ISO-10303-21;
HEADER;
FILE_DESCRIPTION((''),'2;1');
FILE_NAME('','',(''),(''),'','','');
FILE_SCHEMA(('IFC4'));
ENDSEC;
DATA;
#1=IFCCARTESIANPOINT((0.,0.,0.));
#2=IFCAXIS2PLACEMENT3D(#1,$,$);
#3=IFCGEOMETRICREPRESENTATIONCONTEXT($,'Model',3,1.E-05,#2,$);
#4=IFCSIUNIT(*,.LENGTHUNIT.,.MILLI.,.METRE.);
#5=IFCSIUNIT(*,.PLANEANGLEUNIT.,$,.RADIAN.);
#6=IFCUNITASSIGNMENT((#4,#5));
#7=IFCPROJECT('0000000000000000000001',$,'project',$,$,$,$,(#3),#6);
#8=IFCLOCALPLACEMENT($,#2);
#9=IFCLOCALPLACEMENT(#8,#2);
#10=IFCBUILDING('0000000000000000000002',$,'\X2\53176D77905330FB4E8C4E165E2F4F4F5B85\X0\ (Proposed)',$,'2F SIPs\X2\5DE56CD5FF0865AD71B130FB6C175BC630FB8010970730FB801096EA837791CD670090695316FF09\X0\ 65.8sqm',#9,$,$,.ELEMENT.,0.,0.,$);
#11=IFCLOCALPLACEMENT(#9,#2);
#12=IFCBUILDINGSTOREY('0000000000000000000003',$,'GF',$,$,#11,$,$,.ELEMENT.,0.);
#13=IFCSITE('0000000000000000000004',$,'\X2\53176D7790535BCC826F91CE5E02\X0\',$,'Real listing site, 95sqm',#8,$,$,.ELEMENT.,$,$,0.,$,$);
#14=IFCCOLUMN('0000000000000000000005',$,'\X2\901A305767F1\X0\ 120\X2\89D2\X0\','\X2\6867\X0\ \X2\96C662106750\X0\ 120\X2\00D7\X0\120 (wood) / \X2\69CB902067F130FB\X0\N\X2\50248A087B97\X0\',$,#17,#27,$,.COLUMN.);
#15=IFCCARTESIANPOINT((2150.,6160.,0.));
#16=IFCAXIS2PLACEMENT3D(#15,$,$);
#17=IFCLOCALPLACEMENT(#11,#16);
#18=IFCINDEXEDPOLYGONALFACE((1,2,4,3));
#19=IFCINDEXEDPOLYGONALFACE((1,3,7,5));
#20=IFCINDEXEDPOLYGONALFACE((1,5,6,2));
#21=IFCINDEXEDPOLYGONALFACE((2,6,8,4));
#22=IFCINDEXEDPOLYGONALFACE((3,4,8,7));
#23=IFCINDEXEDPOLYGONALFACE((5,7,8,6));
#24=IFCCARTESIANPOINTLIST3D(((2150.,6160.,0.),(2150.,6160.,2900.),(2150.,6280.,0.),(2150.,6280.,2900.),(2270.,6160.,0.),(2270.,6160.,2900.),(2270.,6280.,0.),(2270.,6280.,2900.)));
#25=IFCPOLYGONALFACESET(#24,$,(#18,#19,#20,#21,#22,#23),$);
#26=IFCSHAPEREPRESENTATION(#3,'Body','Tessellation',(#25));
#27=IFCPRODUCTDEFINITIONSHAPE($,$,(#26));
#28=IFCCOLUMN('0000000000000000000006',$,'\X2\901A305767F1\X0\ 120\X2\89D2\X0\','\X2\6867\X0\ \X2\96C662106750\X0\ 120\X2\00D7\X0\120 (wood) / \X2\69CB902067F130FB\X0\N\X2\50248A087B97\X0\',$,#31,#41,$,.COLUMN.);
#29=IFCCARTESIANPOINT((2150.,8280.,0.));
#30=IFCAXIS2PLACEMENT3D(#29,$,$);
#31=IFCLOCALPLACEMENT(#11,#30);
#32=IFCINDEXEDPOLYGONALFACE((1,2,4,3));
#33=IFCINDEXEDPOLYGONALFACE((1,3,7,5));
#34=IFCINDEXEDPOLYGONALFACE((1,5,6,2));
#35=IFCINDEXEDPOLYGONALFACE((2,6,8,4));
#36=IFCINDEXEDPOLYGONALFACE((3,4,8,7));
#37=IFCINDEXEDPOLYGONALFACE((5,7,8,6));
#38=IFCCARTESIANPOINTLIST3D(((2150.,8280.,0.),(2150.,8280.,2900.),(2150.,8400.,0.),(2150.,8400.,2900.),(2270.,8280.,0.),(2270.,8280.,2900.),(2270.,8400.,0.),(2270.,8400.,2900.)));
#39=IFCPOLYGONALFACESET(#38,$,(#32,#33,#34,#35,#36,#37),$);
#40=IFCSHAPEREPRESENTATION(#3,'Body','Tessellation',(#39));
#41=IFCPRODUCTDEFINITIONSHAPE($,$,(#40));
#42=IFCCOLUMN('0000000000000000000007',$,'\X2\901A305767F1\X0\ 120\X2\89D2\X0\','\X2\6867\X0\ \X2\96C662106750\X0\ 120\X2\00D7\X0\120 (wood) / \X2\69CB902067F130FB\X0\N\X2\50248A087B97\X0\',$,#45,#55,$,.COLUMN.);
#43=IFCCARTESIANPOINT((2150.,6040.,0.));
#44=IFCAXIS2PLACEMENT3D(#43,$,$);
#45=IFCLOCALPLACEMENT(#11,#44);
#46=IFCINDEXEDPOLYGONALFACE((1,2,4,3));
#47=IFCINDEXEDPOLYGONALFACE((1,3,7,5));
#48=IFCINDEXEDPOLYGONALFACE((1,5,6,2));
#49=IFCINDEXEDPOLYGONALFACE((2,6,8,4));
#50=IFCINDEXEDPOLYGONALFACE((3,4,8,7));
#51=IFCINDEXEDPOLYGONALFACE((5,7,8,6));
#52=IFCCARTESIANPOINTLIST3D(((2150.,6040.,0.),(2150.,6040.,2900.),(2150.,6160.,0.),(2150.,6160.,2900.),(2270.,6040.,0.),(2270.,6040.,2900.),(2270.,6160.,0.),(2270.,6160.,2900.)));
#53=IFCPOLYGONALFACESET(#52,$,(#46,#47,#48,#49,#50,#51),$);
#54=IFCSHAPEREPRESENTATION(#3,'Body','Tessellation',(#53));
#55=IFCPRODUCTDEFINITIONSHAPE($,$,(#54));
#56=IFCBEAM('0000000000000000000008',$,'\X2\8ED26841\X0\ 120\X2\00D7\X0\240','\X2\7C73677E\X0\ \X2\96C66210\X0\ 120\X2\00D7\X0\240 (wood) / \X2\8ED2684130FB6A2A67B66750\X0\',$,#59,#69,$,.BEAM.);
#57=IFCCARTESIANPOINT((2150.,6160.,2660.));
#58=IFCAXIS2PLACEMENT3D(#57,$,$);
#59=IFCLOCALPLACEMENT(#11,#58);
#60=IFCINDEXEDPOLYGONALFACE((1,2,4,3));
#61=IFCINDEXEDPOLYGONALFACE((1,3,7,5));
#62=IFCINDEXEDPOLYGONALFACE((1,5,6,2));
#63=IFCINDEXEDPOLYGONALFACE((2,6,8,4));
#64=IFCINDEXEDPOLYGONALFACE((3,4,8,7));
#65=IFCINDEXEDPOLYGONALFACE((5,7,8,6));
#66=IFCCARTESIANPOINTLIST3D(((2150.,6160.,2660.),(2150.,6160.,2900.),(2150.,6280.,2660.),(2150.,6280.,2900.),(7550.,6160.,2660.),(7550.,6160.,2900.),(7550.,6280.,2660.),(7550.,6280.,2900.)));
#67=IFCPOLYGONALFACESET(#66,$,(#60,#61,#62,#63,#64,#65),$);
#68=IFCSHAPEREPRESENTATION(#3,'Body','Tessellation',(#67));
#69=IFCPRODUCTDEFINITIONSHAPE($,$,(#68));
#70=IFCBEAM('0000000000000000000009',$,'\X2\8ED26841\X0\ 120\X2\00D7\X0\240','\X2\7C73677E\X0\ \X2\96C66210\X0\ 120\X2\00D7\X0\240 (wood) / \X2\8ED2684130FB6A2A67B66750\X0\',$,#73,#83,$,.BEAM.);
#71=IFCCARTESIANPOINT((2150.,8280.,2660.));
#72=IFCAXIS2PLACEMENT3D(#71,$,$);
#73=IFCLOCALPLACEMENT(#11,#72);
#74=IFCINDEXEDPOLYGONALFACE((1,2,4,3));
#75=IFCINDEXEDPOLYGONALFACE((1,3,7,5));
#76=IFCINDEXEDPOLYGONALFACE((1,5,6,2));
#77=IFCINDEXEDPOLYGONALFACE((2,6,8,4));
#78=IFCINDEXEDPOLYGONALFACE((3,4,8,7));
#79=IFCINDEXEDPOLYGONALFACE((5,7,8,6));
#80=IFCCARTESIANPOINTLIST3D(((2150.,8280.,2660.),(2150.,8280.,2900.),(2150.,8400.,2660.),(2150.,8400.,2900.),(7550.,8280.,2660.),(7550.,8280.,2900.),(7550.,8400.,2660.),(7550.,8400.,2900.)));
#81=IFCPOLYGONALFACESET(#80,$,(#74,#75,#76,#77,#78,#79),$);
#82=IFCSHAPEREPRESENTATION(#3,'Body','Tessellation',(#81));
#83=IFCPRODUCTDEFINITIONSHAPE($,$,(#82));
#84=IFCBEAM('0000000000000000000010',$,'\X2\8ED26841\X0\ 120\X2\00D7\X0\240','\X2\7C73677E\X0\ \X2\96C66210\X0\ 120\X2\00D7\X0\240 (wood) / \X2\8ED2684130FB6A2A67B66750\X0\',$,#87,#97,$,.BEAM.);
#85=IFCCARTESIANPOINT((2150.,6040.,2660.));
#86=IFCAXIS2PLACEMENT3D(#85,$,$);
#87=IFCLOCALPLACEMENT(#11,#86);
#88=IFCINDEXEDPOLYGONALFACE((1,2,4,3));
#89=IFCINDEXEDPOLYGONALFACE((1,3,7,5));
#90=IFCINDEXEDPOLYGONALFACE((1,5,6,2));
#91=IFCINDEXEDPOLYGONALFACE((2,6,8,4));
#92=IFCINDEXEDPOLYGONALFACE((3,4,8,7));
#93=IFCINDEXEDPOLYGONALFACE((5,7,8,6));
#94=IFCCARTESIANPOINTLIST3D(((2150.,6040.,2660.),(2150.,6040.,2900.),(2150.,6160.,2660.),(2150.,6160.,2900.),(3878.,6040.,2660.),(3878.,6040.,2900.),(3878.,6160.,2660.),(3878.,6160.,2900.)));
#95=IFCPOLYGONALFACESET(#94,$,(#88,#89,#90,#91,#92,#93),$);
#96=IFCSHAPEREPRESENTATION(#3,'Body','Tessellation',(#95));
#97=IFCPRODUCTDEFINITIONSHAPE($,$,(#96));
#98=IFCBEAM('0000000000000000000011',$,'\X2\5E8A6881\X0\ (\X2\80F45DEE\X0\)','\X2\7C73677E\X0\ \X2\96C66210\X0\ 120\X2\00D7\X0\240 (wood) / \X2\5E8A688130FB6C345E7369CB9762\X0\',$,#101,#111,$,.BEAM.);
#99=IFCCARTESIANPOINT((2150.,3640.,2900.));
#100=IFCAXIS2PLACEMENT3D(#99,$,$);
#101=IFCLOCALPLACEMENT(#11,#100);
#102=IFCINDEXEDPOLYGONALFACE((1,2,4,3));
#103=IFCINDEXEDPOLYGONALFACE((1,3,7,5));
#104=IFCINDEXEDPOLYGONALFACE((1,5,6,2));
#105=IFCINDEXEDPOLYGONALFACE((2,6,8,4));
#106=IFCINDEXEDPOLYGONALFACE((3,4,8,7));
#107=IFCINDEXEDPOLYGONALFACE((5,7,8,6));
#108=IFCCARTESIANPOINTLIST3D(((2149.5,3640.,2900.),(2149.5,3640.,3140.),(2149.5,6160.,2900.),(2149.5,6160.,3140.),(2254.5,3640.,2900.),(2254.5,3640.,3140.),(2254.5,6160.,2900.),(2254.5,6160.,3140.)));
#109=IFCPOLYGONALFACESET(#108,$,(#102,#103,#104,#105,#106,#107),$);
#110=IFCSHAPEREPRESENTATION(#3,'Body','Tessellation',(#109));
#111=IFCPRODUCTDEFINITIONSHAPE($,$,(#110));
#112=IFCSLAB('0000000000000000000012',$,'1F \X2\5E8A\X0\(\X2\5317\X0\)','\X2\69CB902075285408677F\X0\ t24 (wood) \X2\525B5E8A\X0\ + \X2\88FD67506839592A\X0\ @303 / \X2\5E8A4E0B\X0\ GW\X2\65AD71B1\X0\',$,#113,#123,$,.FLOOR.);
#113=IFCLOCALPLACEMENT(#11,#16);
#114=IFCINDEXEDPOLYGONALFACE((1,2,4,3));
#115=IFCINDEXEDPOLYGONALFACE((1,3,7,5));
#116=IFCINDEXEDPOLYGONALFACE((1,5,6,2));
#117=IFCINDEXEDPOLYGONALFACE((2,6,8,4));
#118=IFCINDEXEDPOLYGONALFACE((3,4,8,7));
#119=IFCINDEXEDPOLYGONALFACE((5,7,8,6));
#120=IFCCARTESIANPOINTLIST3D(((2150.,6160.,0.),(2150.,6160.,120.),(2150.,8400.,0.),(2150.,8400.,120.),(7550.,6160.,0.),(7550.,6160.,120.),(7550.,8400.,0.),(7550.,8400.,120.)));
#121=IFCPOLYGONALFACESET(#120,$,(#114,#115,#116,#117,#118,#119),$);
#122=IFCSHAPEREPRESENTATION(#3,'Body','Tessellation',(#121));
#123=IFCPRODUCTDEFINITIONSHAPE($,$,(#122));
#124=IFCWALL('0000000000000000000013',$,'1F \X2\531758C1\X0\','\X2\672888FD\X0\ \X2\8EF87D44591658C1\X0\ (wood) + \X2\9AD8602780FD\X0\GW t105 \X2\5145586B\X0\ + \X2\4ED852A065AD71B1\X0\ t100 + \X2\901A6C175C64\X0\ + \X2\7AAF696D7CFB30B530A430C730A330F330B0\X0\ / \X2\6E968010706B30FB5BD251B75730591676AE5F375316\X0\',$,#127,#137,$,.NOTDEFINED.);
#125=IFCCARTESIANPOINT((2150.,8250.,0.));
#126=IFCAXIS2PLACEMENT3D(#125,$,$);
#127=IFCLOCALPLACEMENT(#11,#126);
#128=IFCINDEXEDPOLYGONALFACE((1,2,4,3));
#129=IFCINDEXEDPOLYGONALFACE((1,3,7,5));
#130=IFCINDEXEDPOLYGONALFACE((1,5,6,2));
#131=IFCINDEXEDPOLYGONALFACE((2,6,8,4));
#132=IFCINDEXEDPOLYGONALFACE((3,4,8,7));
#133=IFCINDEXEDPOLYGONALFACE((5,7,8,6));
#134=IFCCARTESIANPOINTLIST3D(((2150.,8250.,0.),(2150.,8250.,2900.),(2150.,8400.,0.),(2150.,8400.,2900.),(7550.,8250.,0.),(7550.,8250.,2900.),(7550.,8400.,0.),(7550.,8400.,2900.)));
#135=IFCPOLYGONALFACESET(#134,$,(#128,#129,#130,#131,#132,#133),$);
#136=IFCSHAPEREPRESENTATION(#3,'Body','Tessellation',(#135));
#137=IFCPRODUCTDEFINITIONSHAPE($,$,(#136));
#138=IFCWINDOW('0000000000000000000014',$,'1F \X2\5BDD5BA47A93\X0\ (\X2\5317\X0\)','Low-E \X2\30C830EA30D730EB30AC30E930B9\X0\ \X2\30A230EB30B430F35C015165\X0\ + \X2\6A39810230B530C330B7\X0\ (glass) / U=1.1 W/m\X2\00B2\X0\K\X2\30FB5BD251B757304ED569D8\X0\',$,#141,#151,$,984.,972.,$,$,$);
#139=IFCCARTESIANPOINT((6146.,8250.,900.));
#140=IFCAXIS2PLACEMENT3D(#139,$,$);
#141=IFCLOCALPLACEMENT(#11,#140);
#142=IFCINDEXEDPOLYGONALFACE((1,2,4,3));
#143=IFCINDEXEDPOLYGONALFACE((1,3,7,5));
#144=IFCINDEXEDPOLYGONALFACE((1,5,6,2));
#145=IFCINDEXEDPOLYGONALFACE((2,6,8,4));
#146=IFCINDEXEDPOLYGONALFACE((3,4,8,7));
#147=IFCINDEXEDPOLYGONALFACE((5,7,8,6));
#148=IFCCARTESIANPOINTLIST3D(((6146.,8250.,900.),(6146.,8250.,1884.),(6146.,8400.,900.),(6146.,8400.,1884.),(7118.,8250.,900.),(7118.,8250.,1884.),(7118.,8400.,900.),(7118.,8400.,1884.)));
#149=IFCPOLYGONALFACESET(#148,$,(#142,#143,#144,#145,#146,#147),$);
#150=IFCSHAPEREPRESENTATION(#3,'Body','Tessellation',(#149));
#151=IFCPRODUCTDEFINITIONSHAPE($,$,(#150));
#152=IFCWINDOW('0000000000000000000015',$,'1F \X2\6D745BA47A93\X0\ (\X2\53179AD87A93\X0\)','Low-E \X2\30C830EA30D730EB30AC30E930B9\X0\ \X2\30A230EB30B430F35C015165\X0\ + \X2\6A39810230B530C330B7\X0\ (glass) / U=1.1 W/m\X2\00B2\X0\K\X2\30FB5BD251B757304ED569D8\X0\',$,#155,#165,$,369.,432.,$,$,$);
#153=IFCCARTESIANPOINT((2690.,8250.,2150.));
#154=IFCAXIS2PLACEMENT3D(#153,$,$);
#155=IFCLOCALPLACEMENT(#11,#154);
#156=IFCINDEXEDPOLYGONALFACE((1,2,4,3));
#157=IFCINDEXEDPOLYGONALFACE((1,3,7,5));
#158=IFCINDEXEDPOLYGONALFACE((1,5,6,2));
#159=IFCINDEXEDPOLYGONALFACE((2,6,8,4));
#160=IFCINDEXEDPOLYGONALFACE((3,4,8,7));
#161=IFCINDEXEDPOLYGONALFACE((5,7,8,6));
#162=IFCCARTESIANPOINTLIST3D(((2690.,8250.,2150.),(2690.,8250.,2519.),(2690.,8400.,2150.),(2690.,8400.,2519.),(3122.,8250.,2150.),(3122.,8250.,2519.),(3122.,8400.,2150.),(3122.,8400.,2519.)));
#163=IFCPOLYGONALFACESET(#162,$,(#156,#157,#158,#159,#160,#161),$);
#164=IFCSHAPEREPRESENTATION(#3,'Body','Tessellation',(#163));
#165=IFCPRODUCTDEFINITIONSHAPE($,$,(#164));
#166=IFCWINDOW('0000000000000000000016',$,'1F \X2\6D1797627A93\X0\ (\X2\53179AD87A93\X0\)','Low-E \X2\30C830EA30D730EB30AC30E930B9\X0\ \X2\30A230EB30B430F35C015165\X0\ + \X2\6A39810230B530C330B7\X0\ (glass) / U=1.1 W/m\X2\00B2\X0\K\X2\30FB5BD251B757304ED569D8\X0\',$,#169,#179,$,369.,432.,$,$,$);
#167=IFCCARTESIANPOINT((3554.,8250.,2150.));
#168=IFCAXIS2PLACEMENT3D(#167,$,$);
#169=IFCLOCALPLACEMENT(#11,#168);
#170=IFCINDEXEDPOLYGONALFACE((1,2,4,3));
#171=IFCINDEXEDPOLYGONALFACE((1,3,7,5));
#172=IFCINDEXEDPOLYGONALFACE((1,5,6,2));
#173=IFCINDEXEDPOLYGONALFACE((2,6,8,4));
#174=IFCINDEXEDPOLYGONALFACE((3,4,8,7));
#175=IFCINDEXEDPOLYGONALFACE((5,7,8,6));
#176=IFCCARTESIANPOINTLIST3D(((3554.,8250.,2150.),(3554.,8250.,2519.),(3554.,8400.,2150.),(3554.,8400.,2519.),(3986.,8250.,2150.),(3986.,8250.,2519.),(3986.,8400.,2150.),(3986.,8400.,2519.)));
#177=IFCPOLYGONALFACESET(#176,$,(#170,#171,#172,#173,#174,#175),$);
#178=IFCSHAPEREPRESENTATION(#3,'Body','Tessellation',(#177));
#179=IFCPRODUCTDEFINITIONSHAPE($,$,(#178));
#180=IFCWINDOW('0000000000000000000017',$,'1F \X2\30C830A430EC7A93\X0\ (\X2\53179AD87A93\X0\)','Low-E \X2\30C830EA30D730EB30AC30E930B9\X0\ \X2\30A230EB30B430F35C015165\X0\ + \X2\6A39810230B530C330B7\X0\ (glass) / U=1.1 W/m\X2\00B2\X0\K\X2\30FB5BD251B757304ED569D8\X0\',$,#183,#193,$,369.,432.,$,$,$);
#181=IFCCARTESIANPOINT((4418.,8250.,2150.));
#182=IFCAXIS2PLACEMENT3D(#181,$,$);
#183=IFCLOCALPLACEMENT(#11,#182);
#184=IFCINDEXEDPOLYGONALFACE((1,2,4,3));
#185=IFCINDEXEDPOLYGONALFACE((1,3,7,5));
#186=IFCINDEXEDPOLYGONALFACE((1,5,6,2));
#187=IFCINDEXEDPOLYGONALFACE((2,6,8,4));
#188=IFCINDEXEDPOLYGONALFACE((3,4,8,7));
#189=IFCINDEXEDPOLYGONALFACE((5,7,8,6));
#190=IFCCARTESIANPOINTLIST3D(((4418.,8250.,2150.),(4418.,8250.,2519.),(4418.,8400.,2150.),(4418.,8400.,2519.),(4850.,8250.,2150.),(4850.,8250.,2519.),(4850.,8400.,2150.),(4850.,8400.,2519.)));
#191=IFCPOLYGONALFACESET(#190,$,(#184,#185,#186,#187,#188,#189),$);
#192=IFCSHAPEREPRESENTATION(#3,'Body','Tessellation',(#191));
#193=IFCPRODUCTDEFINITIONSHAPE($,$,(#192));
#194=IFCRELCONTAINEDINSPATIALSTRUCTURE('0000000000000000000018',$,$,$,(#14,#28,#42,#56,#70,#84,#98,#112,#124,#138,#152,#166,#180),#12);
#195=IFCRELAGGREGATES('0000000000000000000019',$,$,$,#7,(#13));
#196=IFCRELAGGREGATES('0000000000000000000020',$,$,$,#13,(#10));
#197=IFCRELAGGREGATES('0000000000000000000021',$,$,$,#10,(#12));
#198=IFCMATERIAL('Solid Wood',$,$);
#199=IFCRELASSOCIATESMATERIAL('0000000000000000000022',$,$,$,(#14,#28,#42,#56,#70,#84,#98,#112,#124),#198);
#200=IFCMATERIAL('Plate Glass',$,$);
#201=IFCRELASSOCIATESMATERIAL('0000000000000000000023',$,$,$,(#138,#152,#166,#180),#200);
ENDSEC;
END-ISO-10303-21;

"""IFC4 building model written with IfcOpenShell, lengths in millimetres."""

from ifc_helpers import new_model, si_unit, frame, frame_2d, origin, place, context, project, spatial, rectangle, extrude, material, element, fill, save


model = new_model("IFC4")

# Units and contexts
model_context = context("Model", 3, precision=1e-05, world=origin())
ifc_project = project(units=[si_unit("LENGTHUNIT", "METRE", prefix="MILLI"), si_unit("PLANEANGLEUNIT", "RADIAN")], contexts=[model_context])

# Site, building, storey
site_placement = place(None, origin())
site = spatial("IfcSite", under=ifc_project, at=site_placement, Name="北海道富良野市", ObjectType="Real listing site, 95sqm", CompositionType="ELEMENT", RefElevation=0.0)
building_placement = place(site_placement, origin())
building = spatial("IfcBuilding", under=site, at=building_placement, Name="北海道・二世帯住宅 (Proposed)", ObjectType="2F SIPs工法（断熱・気密・耐震・耐雪荷重最適化） 65.8sqm", CompositionType="ELEMENT", ElevationOfRefHeight=0.0, ElevationOfTerrain=0.0)
storey_placement = place(building_placement, origin())
storey = spatial("IfcBuildingStorey", under=building, at=storey_placement, Name="GF", CompositionType="ELEMENT", Elevation=0.0)

# Columns
ifc_material_1 = material(Name="Solid Wood")
column_1_placement = place(storey_placement, frame((2150.0, 6160.0, 0.0)))
element("IfcColumn", 1, at=column_1_placement, inside=storey, material=ifc_material_1, Name="通し柱 120角", Description="桧 集成材 120×120 (wood) / 構造柱・N値計算", PredefinedType="COLUMN", context=model_context, shape_type="SweptSolid", body=[
    extrude(rectangle(XDim=120.0, YDim=120.0, at=frame_2d((60.0, 60.0))), frame((2150.0, 6160.0, 0.0)), (0.0, 0.0, 1.0), 2900.0),
])
column_2_placement = place(storey_placement, frame((2150.0, 8280.0, 0.0)))
element("IfcColumn", 2, at=column_2_placement, inside=storey, material=ifc_material_1, Name="通し柱 120角", Description="桧 集成材 120×120 (wood) / 構造柱・N値計算", PredefinedType="COLUMN", context=model_context, shape_type="SweptSolid", body=[
    extrude(rectangle(XDim=120.0, YDim=120.0, at=frame_2d((60.0, 60.0))), frame((2150.0, 8280.0, 0.0)), (0.0, 0.0, 1.0), 2900.0),
])
column_3_placement = place(storey_placement, frame((2150.0, 6040.0, 0.0)))
element("IfcColumn", 3, at=column_3_placement, inside=storey, material=ifc_material_1, Name="通し柱 120角", Description="桧 集成材 120×120 (wood) / 構造柱・N値計算", PredefinedType="COLUMN", context=model_context, shape_type="SweptSolid", body=[
    extrude(rectangle(XDim=120.0, YDim=120.0, at=frame_2d((60.0, 60.0))), frame((2150.0, 6040.0, 0.0)), (0.0, 0.0, 1.0), 2900.0),
])

# Beams
beam_1_placement = place(storey_placement, frame((2150.0, 6160.0, 2660.0)))
element("IfcBeam", 4, at=beam_1_placement, inside=storey, material=ifc_material_1, Name="軒桁 120×240", Description="米松 集成 120×240 (wood) / 軒桁・横架材", PredefinedType="BEAM", context=model_context, shape_type="SweptSolid", body=[
    extrude(rectangle(XDim=5400.0, YDim=120.0, at=frame_2d((2700.0, 60.0))), frame((2150.0, 6160.0, 2660.0)), (0.0, 0.0, 1.0), 240.0),
])
beam_2_placement = place(storey_placement, frame((2150.0, 8280.0, 2660.0)))
element("IfcBeam", 5, at=beam_2_placement, inside=storey, material=ifc_material_1, Name="軒桁 120×240", Description="米松 集成 120×240 (wood) / 軒桁・横架材", PredefinedType="BEAM", context=model_context, shape_type="SweptSolid", body=[
    extrude(rectangle(XDim=5400.0, YDim=120.0, at=frame_2d((2700.0, 60.0))), frame((2150.0, 8280.0, 2660.0)), (0.0, 0.0, 1.0), 240.0),
])
beam_3_placement = place(storey_placement, frame((2150.0, 6040.0, 2660.0)))
element("IfcBeam", 6, at=beam_3_placement, inside=storey, material=ifc_material_1, Name="軒桁 120×240", Description="米松 集成 120×240 (wood) / 軒桁・横架材", PredefinedType="BEAM", context=model_context, shape_type="SweptSolid", body=[
    extrude(rectangle(XDim=1728.0, YDim=120.0, at=frame_2d((864.0, 60.0))), frame((2150.0, 6040.0, 2660.0)), (0.0, 0.0, 1.0), 240.0),
])
beam_4_placement = place(storey_placement, frame((2150.0, 3640.0, 2900.0)))
element("IfcBeam", 7, at=beam_4_placement, inside=storey, material=ifc_material_1, Name="床梁 (胴差)", Description="米松 集成 120×240 (wood) / 床梁・水平構面", PredefinedType="BEAM", context=model_context, shape_type="SweptSolid", body=[
    extrude(rectangle(XDim=105.0, YDim=2520.0, at=frame_2d((52.0, 1260.0))), frame((2150.0, 3640.0, 2900.0)), (0.0, 0.0, 1.0), 240.0),
])

# Slab
slab_placement = place(storey_placement, frame((2150.0, 6160.0, 0.0)))
element("IfcSlab", 8, at=slab_placement, inside=storey, material=ifc_material_1, Name="1F 床(北)", Description="構造用合板 t24 (wood) 剛床 + 製材根太 @303 / 床下 GW断熱", PredefinedType="FLOOR", context=model_context, shape_type="SweptSolid", body=[
    extrude(rectangle(XDim=5400.0, YDim=2240.0, at=frame_2d((2700.0, 1120.0))), frame((2150.0, 6160.0, 0.0)), (0.0, 0.0, 1.0), 120.0),
])

# Wall, openings, windows
wall_1_placement = place(storey_placement, frame((2150.0, 8250.0, 0.0)))
wall_1 = element("IfcWall", 9, at=wall_1_placement, inside=storey, material=ifc_material_1, Name="1F 北壁", Description="木製 軸組外壁 (wood) + 高性能GW t105 充填 + 付加断熱 t100 + 通気層 + 窯業系サイディング / 準耐火・寒冷地外皮強化", PredefinedType="NOTDEFINED", context=model_context, shape_type="SweptSolid", body=[
    extrude(rectangle(XDim=5400.0, YDim=150.0, at=frame_2d((2700.0, 75.0))), frame((2150.0, 8250.0, 0.0)), (0.0, 0.0, 1.0), 2900.0),
])
opening_1_placement = place(storey_placement, frame((6146.0, 8250.0, 900.0)))
opening_1 = element("IfcOpeningElement", 10, at=opening_1_placement, cuts=wall_1, PredefinedType="NOTDEFINED", context=model_context, shape_type="SweptSolid", body=[
    extrude(rectangle(XDim=972.0, YDim=150.0, at=frame_2d((486.0, 75.0))), frame((6146.0, 8250.0, 900.0)), (0.0, 0.0, 1.0), 984.0),
])
opening_2_placement = place(storey_placement, frame((2690.0, 8250.0, 2150.0)))
opening_2 = element("IfcOpeningElement", 11, at=opening_2_placement, cuts=wall_1, PredefinedType="NOTDEFINED", context=model_context, shape_type="SweptSolid", body=[
    extrude(rectangle(XDim=432.0, YDim=150.0, at=frame_2d((216.0, 75.0))), frame((2690.0, 8250.0, 2150.0)), (0.0, 0.0, 1.0), 369.0),
])
opening_3_placement = place(storey_placement, frame((3554.0, 8250.0, 2150.0)))
opening_3 = element("IfcOpeningElement", 12, at=opening_3_placement, cuts=wall_1, PredefinedType="NOTDEFINED", context=model_context, shape_type="SweptSolid", body=[
    extrude(rectangle(XDim=432.0, YDim=150.0, at=frame_2d((216.0, 75.0))), frame((3554.0, 8250.0, 2150.0)), (0.0, 0.0, 1.0), 369.0),
])
opening_4_placement = place(storey_placement, frame((4418.0, 8250.0, 2150.0)))
opening_4 = element("IfcOpeningElement", 13, at=opening_4_placement, cuts=wall_1, PredefinedType="NOTDEFINED", context=model_context, shape_type="SweptSolid", body=[
    extrude(rectangle(XDim=432.0, YDim=150.0, at=frame_2d((216.0, 75.0))), frame((4418.0, 8250.0, 2150.0)), (0.0, 0.0, 1.0), 369.0),
])
ifc_material_2 = material(Name="Plate Glass")
window_1_placement = place(storey_placement, frame((6146.0, 8250.0, 900.0)))
window_1 = element("IfcWindow", 14, at=window_1_placement, inside=storey, material=ifc_material_2, Name="1F 寝室窓 (北)", Description="Low-E トリプルガラス アルゴン封入 + 樹脂サッシ (glass) / U=1.1 W/m²K・寒冷地仕様", OverallHeight=984.0, OverallWidth=972.0, context=model_context, shape_type="SweptSolid", body=[
    extrude(rectangle(XDim=972.0, YDim=150.0, at=frame_2d((486.0, 75.0))), frame((6146.0, 8250.0, 900.0)), (0.0, 0.0, 1.0), 984.0),
])
fill(opening_1, window_1)
window_2_placement = place(storey_placement, frame((2690.0, 8250.0, 2150.0)))
window_2 = element("IfcWindow", 15, at=window_2_placement, inside=storey, material=ifc_material_2, Name="1F 浴室窓 (北高窓)", Description="Low-E トリプルガラス アルゴン封入 + 樹脂サッシ (glass) / U=1.1 W/m²K・寒冷地仕様", OverallHeight=369.0, OverallWidth=432.0, context=model_context, shape_type="SweptSolid", body=[
    extrude(rectangle(XDim=432.0, YDim=150.0, at=frame_2d((216.0, 75.0))), frame((2690.0, 8250.0, 2150.0)), (0.0, 0.0, 1.0), 369.0),
])
fill(opening_2, window_2)
window_3_placement = place(storey_placement, frame((3554.0, 8250.0, 2150.0)))
window_3 = element("IfcWindow", 16, at=window_3_placement, inside=storey, material=ifc_material_2, Name="1F 洗面窓 (北高窓)", Description="Low-E トリプルガラス アルゴン封入 + 樹脂サッシ (glass) / U=1.1 W/m²K・寒冷地仕様", OverallHeight=369.0, OverallWidth=432.0, context=model_context, shape_type="SweptSolid", body=[
    extrude(rectangle(XDim=432.0, YDim=150.0, at=frame_2d((216.0, 75.0))), frame((3554.0, 8250.0, 2150.0)), (0.0, 0.0, 1.0), 369.0),
])
fill(opening_3, window_3)
window_4_placement = place(storey_placement, frame((4418.0, 8250.0, 2150.0)))
window_4 = element("IfcWindow", 17, at=window_4_placement, inside=storey, material=ifc_material_2, Name="1F トイレ窓 (北高窓)", Description="Low-E トリプルガラス アルゴン封入 + 樹脂サッシ (glass) / U=1.1 W/m²K・寒冷地仕様", OverallHeight=369.0, OverallWidth=432.0, context=model_context, shape_type="SweptSolid", body=[
    extrude(rectangle(XDim=432.0, YDim=150.0, at=frame_2d((216.0, 75.0))), frame((4418.0, 8250.0, 2150.0)), (0.0, 0.0, 1.0), 369.0),
])
fill(opening_4, window_4)

save(model, "model.ifc")
